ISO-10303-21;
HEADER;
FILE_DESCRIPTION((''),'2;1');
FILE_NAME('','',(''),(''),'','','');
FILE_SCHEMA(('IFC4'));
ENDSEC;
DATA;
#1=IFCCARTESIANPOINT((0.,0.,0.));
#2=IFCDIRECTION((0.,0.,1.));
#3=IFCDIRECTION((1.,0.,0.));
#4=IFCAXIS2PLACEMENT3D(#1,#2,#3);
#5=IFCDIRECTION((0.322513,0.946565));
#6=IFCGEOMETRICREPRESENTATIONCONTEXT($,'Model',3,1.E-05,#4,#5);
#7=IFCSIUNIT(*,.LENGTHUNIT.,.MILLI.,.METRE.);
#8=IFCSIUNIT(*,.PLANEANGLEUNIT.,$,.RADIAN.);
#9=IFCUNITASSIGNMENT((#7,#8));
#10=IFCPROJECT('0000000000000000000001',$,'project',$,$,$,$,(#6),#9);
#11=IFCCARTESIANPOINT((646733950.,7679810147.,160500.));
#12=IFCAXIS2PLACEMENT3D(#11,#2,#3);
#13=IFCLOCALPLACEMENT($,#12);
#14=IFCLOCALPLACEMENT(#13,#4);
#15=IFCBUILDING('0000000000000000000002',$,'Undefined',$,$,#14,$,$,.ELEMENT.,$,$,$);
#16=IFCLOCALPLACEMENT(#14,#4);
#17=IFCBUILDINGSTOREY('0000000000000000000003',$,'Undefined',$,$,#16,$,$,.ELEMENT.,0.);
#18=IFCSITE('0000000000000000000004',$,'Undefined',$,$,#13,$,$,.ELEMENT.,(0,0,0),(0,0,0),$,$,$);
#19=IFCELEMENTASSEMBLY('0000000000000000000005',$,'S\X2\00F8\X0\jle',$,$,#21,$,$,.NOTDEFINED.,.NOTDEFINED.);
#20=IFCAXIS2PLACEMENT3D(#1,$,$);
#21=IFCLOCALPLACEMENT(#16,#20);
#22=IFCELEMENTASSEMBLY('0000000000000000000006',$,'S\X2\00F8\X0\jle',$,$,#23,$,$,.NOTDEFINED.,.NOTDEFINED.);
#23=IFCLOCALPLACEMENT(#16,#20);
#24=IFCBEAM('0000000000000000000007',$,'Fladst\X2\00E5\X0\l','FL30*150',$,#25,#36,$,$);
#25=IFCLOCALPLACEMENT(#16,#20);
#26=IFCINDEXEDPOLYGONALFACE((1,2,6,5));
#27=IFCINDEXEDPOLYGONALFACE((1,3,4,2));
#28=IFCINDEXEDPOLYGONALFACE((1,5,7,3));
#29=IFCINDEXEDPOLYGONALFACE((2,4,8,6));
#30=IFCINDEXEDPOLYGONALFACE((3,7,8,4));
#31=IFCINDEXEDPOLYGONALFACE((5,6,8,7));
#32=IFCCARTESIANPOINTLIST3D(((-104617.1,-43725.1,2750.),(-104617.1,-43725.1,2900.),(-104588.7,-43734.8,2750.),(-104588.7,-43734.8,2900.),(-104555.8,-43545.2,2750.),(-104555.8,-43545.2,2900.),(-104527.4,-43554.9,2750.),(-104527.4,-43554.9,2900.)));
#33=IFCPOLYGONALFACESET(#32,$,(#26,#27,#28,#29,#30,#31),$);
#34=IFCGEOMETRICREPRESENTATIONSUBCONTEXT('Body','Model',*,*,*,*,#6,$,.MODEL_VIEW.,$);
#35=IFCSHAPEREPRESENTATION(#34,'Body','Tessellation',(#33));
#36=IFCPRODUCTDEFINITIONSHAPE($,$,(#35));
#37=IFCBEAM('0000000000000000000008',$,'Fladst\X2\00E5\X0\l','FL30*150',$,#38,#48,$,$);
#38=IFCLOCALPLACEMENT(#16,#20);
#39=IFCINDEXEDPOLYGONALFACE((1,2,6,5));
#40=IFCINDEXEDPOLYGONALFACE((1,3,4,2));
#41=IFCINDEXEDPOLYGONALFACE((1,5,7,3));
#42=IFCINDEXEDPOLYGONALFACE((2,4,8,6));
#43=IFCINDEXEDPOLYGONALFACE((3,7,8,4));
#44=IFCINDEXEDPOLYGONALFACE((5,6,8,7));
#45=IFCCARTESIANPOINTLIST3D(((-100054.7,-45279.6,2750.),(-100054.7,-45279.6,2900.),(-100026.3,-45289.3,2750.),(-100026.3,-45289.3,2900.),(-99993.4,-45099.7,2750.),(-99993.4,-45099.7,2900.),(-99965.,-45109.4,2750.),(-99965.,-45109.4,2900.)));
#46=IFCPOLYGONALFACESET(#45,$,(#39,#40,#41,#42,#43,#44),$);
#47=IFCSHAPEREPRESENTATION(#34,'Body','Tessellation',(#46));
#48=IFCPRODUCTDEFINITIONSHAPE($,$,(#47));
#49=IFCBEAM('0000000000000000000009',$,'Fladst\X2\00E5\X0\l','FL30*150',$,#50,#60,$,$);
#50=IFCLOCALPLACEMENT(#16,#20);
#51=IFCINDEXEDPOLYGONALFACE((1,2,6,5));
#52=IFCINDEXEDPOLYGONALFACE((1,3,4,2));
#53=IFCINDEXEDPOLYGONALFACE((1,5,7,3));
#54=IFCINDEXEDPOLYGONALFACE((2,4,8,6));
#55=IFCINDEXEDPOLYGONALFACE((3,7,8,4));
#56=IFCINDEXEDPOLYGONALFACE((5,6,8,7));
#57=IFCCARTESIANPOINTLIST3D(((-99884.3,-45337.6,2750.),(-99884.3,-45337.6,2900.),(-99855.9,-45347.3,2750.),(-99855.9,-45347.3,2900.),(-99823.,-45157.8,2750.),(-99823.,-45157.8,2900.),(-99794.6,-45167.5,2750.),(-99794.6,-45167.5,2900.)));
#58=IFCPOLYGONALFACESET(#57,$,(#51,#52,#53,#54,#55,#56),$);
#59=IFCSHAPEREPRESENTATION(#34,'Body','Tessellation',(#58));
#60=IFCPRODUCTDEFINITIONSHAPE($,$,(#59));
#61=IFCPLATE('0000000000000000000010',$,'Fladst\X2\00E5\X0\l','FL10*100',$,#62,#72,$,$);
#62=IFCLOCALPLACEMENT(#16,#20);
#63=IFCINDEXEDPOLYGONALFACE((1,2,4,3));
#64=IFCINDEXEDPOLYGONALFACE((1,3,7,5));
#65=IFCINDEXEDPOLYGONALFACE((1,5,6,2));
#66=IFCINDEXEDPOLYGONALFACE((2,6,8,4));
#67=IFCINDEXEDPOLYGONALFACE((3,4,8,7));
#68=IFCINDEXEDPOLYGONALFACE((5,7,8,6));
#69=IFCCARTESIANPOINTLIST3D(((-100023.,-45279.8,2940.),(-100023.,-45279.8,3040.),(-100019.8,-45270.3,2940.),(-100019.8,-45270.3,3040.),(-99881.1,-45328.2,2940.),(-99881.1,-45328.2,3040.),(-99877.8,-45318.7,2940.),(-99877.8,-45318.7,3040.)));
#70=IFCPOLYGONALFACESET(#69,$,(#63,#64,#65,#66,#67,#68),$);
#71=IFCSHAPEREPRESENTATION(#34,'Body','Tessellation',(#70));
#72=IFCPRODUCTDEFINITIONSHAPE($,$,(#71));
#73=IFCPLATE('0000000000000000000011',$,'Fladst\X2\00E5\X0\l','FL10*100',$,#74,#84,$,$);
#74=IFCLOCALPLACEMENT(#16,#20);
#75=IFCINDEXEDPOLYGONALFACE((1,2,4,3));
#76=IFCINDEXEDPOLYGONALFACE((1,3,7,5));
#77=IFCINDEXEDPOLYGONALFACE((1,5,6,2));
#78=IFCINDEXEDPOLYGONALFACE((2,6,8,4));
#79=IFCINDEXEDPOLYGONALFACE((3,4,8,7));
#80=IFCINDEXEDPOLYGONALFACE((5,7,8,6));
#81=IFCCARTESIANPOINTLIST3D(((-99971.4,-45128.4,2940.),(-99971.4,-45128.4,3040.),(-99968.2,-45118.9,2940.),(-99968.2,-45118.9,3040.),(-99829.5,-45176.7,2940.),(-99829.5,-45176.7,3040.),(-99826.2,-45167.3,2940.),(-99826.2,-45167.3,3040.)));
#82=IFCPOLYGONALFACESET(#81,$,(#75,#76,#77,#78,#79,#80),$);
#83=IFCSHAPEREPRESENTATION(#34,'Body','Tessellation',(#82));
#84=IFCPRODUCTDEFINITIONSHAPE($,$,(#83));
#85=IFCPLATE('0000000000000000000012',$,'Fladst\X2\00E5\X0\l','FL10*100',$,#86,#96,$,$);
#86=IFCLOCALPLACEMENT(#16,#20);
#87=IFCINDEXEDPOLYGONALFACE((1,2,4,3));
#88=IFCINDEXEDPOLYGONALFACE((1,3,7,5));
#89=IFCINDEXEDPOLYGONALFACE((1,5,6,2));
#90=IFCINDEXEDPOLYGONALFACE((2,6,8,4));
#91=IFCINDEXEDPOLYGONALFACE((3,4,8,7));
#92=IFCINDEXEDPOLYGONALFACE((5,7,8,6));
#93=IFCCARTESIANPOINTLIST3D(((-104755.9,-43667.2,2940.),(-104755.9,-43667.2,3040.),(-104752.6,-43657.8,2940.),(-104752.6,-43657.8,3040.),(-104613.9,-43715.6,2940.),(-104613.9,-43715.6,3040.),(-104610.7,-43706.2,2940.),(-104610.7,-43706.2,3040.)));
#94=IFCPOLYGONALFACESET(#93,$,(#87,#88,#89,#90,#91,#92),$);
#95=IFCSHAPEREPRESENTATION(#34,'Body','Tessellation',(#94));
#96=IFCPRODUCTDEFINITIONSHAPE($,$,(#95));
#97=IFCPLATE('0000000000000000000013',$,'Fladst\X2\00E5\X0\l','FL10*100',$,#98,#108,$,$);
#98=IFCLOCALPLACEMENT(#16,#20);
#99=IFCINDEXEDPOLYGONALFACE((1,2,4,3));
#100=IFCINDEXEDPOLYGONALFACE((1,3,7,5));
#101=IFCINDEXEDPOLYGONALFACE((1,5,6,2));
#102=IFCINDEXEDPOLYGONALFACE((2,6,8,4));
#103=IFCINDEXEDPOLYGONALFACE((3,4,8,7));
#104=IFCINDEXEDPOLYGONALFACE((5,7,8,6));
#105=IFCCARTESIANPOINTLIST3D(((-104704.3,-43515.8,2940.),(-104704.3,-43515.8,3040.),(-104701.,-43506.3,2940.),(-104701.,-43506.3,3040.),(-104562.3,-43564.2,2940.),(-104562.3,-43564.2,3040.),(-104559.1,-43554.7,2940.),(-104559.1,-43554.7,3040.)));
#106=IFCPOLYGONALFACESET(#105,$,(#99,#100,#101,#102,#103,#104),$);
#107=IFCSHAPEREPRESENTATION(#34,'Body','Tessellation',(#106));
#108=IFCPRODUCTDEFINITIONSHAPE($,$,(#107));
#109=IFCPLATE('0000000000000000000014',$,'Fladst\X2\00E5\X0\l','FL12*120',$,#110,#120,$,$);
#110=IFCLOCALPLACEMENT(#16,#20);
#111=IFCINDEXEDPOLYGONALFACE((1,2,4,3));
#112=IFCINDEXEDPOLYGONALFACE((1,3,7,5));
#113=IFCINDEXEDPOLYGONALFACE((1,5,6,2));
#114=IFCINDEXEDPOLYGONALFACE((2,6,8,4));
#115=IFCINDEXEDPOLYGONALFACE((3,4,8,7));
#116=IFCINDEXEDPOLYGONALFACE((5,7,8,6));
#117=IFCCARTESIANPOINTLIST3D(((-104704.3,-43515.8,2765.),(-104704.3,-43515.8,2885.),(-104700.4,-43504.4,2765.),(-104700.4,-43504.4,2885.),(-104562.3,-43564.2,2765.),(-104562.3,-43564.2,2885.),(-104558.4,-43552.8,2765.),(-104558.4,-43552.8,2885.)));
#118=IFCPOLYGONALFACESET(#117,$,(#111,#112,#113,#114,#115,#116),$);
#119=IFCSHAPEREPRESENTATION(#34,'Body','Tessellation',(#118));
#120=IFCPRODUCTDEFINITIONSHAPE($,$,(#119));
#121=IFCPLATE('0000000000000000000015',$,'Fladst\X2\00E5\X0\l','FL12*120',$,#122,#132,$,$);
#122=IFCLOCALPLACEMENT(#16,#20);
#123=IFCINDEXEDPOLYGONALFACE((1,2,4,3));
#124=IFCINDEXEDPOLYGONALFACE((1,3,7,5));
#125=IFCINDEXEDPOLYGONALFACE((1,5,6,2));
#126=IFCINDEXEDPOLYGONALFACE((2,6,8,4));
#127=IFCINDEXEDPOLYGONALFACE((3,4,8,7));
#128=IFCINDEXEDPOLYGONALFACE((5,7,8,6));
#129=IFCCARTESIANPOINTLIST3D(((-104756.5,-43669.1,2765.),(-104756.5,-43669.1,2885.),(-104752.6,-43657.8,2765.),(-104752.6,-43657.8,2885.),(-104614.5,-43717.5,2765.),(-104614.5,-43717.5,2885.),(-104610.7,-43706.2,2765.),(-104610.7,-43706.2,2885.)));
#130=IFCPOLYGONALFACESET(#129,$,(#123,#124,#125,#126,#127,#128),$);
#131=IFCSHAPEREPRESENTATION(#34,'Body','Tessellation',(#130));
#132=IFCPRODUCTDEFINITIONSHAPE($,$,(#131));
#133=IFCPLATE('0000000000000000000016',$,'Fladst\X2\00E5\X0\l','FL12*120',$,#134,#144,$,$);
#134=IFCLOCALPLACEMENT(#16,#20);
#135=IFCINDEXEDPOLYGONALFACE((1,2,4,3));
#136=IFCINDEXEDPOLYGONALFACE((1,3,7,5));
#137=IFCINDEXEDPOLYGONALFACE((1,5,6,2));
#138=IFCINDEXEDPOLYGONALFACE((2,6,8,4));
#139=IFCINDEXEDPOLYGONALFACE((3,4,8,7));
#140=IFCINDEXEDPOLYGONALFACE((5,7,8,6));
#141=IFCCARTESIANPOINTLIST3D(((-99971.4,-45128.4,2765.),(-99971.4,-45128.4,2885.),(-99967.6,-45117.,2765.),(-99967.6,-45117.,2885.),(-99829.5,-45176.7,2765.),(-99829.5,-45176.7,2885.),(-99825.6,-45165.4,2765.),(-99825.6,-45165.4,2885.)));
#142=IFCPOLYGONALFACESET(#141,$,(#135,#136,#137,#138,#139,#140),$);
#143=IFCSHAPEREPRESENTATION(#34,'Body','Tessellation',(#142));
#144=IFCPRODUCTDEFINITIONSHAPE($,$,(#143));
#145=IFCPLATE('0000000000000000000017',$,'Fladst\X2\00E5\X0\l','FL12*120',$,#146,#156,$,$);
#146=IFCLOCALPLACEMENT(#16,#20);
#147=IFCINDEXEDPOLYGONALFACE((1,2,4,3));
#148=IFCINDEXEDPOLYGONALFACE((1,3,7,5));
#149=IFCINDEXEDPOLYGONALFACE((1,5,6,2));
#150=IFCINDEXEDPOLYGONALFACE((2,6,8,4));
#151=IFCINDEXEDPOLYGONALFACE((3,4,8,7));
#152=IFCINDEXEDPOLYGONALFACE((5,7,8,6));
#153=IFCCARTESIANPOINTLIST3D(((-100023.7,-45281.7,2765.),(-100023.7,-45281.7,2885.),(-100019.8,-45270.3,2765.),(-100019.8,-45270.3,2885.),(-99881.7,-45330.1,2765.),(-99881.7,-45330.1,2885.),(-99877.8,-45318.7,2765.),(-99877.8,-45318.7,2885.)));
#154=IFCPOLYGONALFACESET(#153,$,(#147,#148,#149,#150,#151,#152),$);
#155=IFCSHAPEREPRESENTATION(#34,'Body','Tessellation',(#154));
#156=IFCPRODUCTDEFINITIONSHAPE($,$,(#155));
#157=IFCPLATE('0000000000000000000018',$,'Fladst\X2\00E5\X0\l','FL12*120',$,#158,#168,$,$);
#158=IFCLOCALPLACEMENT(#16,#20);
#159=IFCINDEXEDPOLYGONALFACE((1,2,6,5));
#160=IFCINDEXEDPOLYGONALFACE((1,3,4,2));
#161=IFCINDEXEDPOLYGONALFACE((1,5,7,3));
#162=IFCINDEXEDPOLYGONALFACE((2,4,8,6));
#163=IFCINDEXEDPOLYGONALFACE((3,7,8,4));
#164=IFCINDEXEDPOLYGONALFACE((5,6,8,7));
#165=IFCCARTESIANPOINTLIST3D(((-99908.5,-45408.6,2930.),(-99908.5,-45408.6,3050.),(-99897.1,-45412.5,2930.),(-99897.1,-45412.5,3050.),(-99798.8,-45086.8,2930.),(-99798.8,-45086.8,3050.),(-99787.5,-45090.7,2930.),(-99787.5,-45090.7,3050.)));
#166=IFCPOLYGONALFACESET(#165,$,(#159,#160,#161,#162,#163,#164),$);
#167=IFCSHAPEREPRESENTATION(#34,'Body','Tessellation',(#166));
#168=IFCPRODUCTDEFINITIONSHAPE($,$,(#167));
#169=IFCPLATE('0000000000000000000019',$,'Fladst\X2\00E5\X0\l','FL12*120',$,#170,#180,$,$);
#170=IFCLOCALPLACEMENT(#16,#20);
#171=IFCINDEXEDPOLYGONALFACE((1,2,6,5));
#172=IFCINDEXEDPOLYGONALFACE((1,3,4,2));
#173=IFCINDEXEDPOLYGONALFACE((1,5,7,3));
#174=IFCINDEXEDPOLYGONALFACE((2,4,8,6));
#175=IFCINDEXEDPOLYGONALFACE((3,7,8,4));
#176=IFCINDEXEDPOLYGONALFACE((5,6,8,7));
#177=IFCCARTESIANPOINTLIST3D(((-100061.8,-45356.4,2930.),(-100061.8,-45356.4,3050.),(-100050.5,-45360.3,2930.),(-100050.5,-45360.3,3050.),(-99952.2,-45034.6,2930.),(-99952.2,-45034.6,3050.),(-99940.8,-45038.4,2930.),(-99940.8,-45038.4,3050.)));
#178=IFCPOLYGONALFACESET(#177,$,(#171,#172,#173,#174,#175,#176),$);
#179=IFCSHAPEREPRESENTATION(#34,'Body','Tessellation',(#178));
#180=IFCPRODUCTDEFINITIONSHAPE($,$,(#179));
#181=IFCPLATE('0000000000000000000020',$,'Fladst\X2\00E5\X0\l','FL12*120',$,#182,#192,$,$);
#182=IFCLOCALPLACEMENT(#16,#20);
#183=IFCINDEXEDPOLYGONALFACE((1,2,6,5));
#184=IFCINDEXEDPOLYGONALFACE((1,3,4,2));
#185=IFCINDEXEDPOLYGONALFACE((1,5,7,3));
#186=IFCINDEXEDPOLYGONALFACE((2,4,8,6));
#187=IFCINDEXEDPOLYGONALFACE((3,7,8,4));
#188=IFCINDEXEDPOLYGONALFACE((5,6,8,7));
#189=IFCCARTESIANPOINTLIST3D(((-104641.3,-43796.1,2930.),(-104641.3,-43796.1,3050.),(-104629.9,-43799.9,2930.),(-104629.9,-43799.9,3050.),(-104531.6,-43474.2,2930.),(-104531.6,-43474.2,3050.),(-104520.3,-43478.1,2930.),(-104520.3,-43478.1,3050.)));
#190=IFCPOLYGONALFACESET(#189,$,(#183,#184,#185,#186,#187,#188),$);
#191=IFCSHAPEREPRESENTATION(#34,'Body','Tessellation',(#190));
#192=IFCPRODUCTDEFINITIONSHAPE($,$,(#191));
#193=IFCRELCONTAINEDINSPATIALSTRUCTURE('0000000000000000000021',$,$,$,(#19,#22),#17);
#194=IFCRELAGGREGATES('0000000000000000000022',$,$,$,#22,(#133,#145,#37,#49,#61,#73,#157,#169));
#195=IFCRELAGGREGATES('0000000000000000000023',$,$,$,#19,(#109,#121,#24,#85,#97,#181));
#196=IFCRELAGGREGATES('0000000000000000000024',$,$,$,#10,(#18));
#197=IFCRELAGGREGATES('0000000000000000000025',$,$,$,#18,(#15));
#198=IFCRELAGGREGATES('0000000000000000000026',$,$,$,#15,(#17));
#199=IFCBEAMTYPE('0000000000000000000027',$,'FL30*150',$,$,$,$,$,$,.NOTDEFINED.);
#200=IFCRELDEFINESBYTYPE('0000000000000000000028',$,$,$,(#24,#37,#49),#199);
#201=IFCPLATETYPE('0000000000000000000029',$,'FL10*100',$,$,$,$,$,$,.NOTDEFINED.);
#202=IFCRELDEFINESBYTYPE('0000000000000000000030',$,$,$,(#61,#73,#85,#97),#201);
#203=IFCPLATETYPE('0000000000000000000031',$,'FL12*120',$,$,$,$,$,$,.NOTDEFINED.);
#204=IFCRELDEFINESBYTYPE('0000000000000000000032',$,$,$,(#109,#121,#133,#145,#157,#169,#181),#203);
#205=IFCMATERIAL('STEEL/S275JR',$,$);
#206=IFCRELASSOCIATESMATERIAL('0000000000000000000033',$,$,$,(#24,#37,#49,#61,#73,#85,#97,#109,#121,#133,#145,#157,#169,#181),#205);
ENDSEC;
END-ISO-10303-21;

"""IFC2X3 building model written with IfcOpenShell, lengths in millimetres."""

from ifc_helpers import new_model, si_unit, direction, frame, origin_with_axes, origin_2d_with_axis, place, context, subcontext, project, spatial, polyline, rectangle, outline, extrude, material, type_object, element, aggregate, save


model = new_model("IFC2X3")

# Units and contexts
model_context = context("Model", 3, precision=1e-05, world=origin_with_axes(), true_north=direction((0.322513, 0.946565)))
body_context = subcontext(model_context, "Body", "Model", "MODEL_VIEW")
ifc_project = project(units=[si_unit("LENGTHUNIT", "METRE", prefix="MILLI"), si_unit("PLANEANGLEUNIT", "RADIAN")], contexts=[model_context])

# Site, building, storey
site_placement = place(None, frame((646733950.0, 7679810147.0, 160500.0), z_axis=(0.0, 0.0, 1.0), x_axis=(1.0, 0.0, 0.0)))
site = spatial("IfcSite", under=ifc_project, at=site_placement, Name="Undefined", CompositionType="ELEMENT", RefLatitude=(0, 0, 0), RefLongitude=(0, 0, 0))
building_placement = place(site_placement, origin_with_axes())
building = spatial("IfcBuilding", under=site, at=building_placement, Name="Undefined", CompositionType="ELEMENT")
storey_placement = place(building_placement, origin_with_axes())
storey = spatial("IfcBuildingStorey", under=building, at=storey_placement, Name="Undefined", CompositionType="ELEMENT", Elevation=0.0)

# Element assemblies
assembly_1_placement = place(storey_placement, origin_with_axes())
assembly_1 = element("IfcElementAssembly", 1, at=assembly_1_placement, inside=storey, Name="Søjle", AssemblyPlace="NOTDEFINED", PredefinedType="NOTDEFINED")
assembly_2_placement = place(storey_placement, origin_with_axes())
assembly_2 = element("IfcElementAssembly", 2, at=assembly_2_placement, inside=storey, Name="Søjle", AssemblyPlace="NOTDEFINED", PredefinedType="NOTDEFINED")

# Beams
ifc_material_1 = material(Name="STEEL/S275JR")
beam_type = type_object("IfcBeamType", Name="FL30*150", PredefinedType="NOTDEFINED")
beam_1_placement = place(assembly_1_placement, frame((-104572.3, -43640.0, 2900.0), z_axis=(-0.322513, -0.946565, 0.0), x_axis=(0.0, 0.0, -1.0)))
beam_1 = element("IfcBeam", 3, at=beam_1_placement, type_object=beam_type, material=ifc_material_1, Name="Fladstål", Description="FL30*150", context=body_context, shape_type="SweptSolid", body=[
    extrude(rectangle(XDim=30.0, YDim=190.0, at=origin_2d_with_axis()), frame((150.0, 0.0, 0.0), z_axis=(-1.0, 0.0, 0.0), x_axis=(0.0, -1.0, 0.0)), (0.0, 0.0, 1.0), 150.0),
])
beam_2_placement = place(assembly_2_placement, frame((-100009.8, -45194.5, 2900.0), z_axis=(-0.322513, -0.946565, 0.0), x_axis=(0.0, 0.0, -1.0)))
beam_2 = element("IfcBeam", 4, at=beam_2_placement, type_object=beam_type, material=ifc_material_1, Name="Fladstål", Description="FL30*150", context=body_context, shape_type="SweptSolid", body=[
    extrude(rectangle(XDim=30.0, YDim=190.0, at=origin_2d_with_axis()), frame((150.0, 0.0, 0.0), z_axis=(-1.0, 0.0, 0.0), x_axis=(0.0, -1.0, 0.0)), (0.0, 0.0, 1.0), 150.0),
])
beam_3_placement = place(assembly_2_placement, frame((-99839.4, -45252.6, 2900.0), z_axis=(-0.322513, -0.946565, 0.0), x_axis=(0.0, 0.0, -1.0)))
beam_3 = element("IfcBeam", 5, at=beam_3_placement, type_object=beam_type, material=ifc_material_1, Name="Fladstål", Description="FL30*150", context=body_context, shape_type="SweptSolid", body=[
    extrude(rectangle(XDim=30.0, YDim=190.0, at=origin_2d_with_axis()), frame((150.0, 0.0, 0.0), z_axis=(-1.0, 0.0, 0.0), x_axis=(0.0, -1.0, 0.0)), (0.0, 0.0, 1.0), 150.0),
])

# Plates
plate_type_1 = type_object("IfcPlateType", Name="FL10*100", PredefinedType="NOTDEFINED")
plate_1_placement = place(assembly_2_placement, frame((-99879.4, -45323.5, 3040.0), z_axis=(-0.322513, -0.946565, 0.0), x_axis=(-0.946565, 0.322513, 0.0)))
plate_1 = element("IfcPlate", 6, at=plate_1_placement, type_object=plate_type_1, material=ifc_material_1, Name="Fladstål", Description="FL10*100", context=body_context, shape_type="SweptSolid", body=[
    extrude(outline(polyline([(0.0, 0.0), (150.0, 0.0), (150.0, 100.0), (0.0, 100.0), (0.0, 0.0)])), frame((0.0, 0.0, -5.0), z_axis=(0.0, 0.0, 1.0), x_axis=(1.0, 0.0, 0.0)), (0.0, 0.0, 1.0), 10.0),
])
plate_2_placement = place(assembly_2_placement, frame((-99827.8, -45172.0, 3040.0), z_axis=(-0.322513, -0.946565, 0.0), x_axis=(-0.946565, 0.322513, 0.0)))
plate_2 = element("IfcPlate", 7, at=plate_2_placement, type_object=plate_type_1, material=ifc_material_1, Name="Fladstål", Description="FL10*100", context=body_context, shape_type="SweptSolid", body=[
    extrude(outline(polyline([(0.0, 0.0), (150.0, 0.0), (150.0, 100.0), (0.0, 100.0), (0.0, 0.0)])), frame((0.0, 0.0, -5.0), z_axis=(0.0, 0.0, 1.0), x_axis=(1.0, 0.0, 0.0)), (0.0, 0.0, 1.0), 10.0),
])
plate_3_placement = place(assembly_1_placement, frame((-104612.3, -43710.9, 3040.0), z_axis=(-0.322513, -0.946565, 0.0), x_axis=(-0.946565, 0.322513, 0.0)))
plate_3 = element("IfcPlate", 8, at=plate_3_placement, type_object=plate_type_1, material=ifc_material_1, Name="Fladstål", Description="FL10*100", context=body_context, shape_type="SweptSolid", body=[
    extrude(outline(polyline([(0.0, 0.0), (150.0, 0.0), (150.0, 100.0), (0.0, 100.0), (0.0, 0.0)])), frame((0.0, 0.0, -5.0), z_axis=(0.0, 0.0, 1.0), x_axis=(1.0, 0.0, 0.0)), (0.0, 0.0, 1.0), 10.0),
])
plate_4_placement = place(assembly_1_placement, frame((-104560.7, -43559.4, 3040.0), z_axis=(-0.322513, -0.946565, 0.0), x_axis=(-0.946565, 0.322513, 0.0)))
plate_4 = element("IfcPlate", 9, at=plate_4_placement, type_object=plate_type_1, material=ifc_material_1, Name="Fladstål", Description="FL10*100", context=body_context, shape_type="SweptSolid", body=[
    extrude(outline(polyline([(0.0, 0.0), (150.0, 0.0), (150.0, 100.0), (0.0, 100.0), (0.0, 0.0)])), frame((0.0, 0.0, -5.0), z_axis=(0.0, 0.0, 1.0), x_axis=(1.0, 0.0, 0.0)), (0.0, 0.0, 1.0), 10.0),
])
plate_type_2 = type_object("IfcPlateType", Name="FL12*120", PredefinedType="NOTDEFINED")
plate_5_placement = place(assembly_1_placement, frame((-104560.3, -43558.5, 2885.0), z_axis=(-0.322513, -0.946565, 0.0), x_axis=(-0.946565, 0.322513, 0.0)))
plate_5 = element("IfcPlate", 10, at=plate_5_placement, type_object=plate_type_2, material=ifc_material_1, Name="Fladstål", Description="FL12*120", context=body_context, shape_type="SweptSolid", body=[
    extrude(outline(polyline([(0.0, 0.0), (150.0, 0.0), (150.0, 120.0), (0.0, 120.0), (0.0, 0.0)])), frame((0.0, 0.0, -6.0), z_axis=(0.0, 0.0, 1.0), x_axis=(1.0, 0.0, 0.0)), (0.0, 0.0, 1.0), 12.0),
])
plate_6_placement = place(assembly_1_placement, frame((-104612.6, -43711.8, 2885.0), z_axis=(-0.322513, -0.946565, 0.0), x_axis=(-0.946565, 0.322513, 0.0)))
plate_6 = element("IfcPlate", 11, at=plate_6_placement, type_object=plate_type_2, material=ifc_material_1, Name="Fladstål", Description="FL12*120", context=body_context, shape_type="SweptSolid", body=[
    extrude(outline(polyline([(0.0, 0.0), (150.0, 0.0), (150.0, 120.0), (0.0, 120.0), (0.0, 0.0)])), frame((0.0, 0.0, -6.0), z_axis=(0.0, 0.0, 1.0), x_axis=(1.0, 0.0, 0.0)), (0.0, 0.0, 1.0), 12.0),
])
plate_7_placement = place(assembly_2_placement, frame((-99827.5, -45171.1, 2885.0), z_axis=(-0.322513, -0.946565, 0.0), x_axis=(-0.946565, 0.322513, 0.0)))
plate_7 = element("IfcPlate", 12, at=plate_7_placement, type_object=plate_type_2, material=ifc_material_1, Name="Fladstål", Description="FL12*120", context=body_context, shape_type="SweptSolid", body=[
    extrude(outline(polyline([(0.0, 0.0), (150.0, 0.0), (150.0, 120.0), (0.0, 120.0), (0.0, 0.0)])), frame((0.0, 0.0, -6.0), z_axis=(0.0, 0.0, 1.0), x_axis=(1.0, 0.0, 0.0)), (0.0, 0.0, 1.0), 12.0),
])
plate_8_placement = place(assembly_2_placement, frame((-99879.8, -45324.4, 2885.0), z_axis=(-0.322513, -0.946565, 0.0), x_axis=(-0.946565, 0.322513, 0.0)))
plate_8 = element("IfcPlate", 13, at=plate_8_placement, type_object=plate_type_2, material=ifc_material_1, Name="Fladstål", Description="FL12*120", context=body_context, shape_type="SweptSolid", body=[
    extrude(outline(polyline([(0.0, 0.0), (150.0, 0.0), (150.0, 120.0), (0.0, 120.0), (0.0, 0.0)])), frame((0.0, 0.0, -6.0), z_axis=(0.0, 0.0, 1.0), x_axis=(1.0, 0.0, 0.0)), (0.0, 0.0, 1.0), 12.0),
])
plate_9_placement = place(assembly_2_placement, frame((-99793.1, -45088.7, 3050.0), z_axis=(0.946565, -0.322513, 0.0), x_axis=(-0.322513, -0.946565, 0.0)))
plate_9 = element("IfcPlate", 14, at=plate_9_placement, type_object=plate_type_2, material=ifc_material_1, Name="Fladstål", Description="FL12*120", context=body_context, shape_type="SweptSolid", body=[
    extrude(outline(polyline([(0.0, 0.0), (340.0, 0.0), (340.0, 120.0), (0.0, 120.0), (0.0, 0.0)])), frame((0.0, 0.0, -6.0), z_axis=(0.0, 0.0, 1.0), x_axis=(1.0, 0.0, 0.0)), (0.0, 0.0, 1.0), 12.0),
])
plate_10_placement = place(assembly_2_placement, frame((-99946.5, -45036.5, 3050.0), z_axis=(0.946565, -0.322513, 0.0), x_axis=(-0.322513, -0.946565, 0.0)))
plate_10 = element("IfcPlate", 15, at=plate_10_placement, type_object=plate_type_2, material=ifc_material_1, Name="Fladstål", Description="FL12*120", context=body_context, shape_type="SweptSolid", body=[
    extrude(outline(polyline([(0.0, 0.0), (340.0, 0.0), (340.0, 120.0), (0.0, 120.0), (0.0, 0.0)])), frame((0.0, 0.0, -6.0), z_axis=(0.0, 0.0, 1.0), x_axis=(1.0, 0.0, 0.0)), (0.0, 0.0, 1.0), 12.0),
])
plate_11_placement = place(assembly_1_placement, frame((-104526.0, -43476.2, 3050.0), z_axis=(0.946565, -0.322513, 0.0), x_axis=(-0.322513, -0.946565, 0.0)))
plate_11 = element("IfcPlate", 16, at=plate_11_placement, type_object=plate_type_2, material=ifc_material_1, Name="Fladstål", Description="FL12*120", context=body_context, shape_type="SweptSolid", body=[
    extrude(outline(polyline([(0.0, 0.0), (340.0, 0.0), (340.0, 120.0), (0.0, 120.0), (0.0, 0.0)])), frame((0.0, 0.0, -6.0), z_axis=(0.0, 0.0, 1.0), x_axis=(1.0, 0.0, 0.0)), (0.0, 0.0, 1.0), 12.0),
])

aggregate(assembly_2, [plate_7, plate_8, beam_2, beam_3, plate_1, plate_2, plate_9, plate_10])
aggregate(assembly_1, [plate_5, plate_6, beam_1, plate_3, plate_4, plate_11])

save(model, "model.ifc")
